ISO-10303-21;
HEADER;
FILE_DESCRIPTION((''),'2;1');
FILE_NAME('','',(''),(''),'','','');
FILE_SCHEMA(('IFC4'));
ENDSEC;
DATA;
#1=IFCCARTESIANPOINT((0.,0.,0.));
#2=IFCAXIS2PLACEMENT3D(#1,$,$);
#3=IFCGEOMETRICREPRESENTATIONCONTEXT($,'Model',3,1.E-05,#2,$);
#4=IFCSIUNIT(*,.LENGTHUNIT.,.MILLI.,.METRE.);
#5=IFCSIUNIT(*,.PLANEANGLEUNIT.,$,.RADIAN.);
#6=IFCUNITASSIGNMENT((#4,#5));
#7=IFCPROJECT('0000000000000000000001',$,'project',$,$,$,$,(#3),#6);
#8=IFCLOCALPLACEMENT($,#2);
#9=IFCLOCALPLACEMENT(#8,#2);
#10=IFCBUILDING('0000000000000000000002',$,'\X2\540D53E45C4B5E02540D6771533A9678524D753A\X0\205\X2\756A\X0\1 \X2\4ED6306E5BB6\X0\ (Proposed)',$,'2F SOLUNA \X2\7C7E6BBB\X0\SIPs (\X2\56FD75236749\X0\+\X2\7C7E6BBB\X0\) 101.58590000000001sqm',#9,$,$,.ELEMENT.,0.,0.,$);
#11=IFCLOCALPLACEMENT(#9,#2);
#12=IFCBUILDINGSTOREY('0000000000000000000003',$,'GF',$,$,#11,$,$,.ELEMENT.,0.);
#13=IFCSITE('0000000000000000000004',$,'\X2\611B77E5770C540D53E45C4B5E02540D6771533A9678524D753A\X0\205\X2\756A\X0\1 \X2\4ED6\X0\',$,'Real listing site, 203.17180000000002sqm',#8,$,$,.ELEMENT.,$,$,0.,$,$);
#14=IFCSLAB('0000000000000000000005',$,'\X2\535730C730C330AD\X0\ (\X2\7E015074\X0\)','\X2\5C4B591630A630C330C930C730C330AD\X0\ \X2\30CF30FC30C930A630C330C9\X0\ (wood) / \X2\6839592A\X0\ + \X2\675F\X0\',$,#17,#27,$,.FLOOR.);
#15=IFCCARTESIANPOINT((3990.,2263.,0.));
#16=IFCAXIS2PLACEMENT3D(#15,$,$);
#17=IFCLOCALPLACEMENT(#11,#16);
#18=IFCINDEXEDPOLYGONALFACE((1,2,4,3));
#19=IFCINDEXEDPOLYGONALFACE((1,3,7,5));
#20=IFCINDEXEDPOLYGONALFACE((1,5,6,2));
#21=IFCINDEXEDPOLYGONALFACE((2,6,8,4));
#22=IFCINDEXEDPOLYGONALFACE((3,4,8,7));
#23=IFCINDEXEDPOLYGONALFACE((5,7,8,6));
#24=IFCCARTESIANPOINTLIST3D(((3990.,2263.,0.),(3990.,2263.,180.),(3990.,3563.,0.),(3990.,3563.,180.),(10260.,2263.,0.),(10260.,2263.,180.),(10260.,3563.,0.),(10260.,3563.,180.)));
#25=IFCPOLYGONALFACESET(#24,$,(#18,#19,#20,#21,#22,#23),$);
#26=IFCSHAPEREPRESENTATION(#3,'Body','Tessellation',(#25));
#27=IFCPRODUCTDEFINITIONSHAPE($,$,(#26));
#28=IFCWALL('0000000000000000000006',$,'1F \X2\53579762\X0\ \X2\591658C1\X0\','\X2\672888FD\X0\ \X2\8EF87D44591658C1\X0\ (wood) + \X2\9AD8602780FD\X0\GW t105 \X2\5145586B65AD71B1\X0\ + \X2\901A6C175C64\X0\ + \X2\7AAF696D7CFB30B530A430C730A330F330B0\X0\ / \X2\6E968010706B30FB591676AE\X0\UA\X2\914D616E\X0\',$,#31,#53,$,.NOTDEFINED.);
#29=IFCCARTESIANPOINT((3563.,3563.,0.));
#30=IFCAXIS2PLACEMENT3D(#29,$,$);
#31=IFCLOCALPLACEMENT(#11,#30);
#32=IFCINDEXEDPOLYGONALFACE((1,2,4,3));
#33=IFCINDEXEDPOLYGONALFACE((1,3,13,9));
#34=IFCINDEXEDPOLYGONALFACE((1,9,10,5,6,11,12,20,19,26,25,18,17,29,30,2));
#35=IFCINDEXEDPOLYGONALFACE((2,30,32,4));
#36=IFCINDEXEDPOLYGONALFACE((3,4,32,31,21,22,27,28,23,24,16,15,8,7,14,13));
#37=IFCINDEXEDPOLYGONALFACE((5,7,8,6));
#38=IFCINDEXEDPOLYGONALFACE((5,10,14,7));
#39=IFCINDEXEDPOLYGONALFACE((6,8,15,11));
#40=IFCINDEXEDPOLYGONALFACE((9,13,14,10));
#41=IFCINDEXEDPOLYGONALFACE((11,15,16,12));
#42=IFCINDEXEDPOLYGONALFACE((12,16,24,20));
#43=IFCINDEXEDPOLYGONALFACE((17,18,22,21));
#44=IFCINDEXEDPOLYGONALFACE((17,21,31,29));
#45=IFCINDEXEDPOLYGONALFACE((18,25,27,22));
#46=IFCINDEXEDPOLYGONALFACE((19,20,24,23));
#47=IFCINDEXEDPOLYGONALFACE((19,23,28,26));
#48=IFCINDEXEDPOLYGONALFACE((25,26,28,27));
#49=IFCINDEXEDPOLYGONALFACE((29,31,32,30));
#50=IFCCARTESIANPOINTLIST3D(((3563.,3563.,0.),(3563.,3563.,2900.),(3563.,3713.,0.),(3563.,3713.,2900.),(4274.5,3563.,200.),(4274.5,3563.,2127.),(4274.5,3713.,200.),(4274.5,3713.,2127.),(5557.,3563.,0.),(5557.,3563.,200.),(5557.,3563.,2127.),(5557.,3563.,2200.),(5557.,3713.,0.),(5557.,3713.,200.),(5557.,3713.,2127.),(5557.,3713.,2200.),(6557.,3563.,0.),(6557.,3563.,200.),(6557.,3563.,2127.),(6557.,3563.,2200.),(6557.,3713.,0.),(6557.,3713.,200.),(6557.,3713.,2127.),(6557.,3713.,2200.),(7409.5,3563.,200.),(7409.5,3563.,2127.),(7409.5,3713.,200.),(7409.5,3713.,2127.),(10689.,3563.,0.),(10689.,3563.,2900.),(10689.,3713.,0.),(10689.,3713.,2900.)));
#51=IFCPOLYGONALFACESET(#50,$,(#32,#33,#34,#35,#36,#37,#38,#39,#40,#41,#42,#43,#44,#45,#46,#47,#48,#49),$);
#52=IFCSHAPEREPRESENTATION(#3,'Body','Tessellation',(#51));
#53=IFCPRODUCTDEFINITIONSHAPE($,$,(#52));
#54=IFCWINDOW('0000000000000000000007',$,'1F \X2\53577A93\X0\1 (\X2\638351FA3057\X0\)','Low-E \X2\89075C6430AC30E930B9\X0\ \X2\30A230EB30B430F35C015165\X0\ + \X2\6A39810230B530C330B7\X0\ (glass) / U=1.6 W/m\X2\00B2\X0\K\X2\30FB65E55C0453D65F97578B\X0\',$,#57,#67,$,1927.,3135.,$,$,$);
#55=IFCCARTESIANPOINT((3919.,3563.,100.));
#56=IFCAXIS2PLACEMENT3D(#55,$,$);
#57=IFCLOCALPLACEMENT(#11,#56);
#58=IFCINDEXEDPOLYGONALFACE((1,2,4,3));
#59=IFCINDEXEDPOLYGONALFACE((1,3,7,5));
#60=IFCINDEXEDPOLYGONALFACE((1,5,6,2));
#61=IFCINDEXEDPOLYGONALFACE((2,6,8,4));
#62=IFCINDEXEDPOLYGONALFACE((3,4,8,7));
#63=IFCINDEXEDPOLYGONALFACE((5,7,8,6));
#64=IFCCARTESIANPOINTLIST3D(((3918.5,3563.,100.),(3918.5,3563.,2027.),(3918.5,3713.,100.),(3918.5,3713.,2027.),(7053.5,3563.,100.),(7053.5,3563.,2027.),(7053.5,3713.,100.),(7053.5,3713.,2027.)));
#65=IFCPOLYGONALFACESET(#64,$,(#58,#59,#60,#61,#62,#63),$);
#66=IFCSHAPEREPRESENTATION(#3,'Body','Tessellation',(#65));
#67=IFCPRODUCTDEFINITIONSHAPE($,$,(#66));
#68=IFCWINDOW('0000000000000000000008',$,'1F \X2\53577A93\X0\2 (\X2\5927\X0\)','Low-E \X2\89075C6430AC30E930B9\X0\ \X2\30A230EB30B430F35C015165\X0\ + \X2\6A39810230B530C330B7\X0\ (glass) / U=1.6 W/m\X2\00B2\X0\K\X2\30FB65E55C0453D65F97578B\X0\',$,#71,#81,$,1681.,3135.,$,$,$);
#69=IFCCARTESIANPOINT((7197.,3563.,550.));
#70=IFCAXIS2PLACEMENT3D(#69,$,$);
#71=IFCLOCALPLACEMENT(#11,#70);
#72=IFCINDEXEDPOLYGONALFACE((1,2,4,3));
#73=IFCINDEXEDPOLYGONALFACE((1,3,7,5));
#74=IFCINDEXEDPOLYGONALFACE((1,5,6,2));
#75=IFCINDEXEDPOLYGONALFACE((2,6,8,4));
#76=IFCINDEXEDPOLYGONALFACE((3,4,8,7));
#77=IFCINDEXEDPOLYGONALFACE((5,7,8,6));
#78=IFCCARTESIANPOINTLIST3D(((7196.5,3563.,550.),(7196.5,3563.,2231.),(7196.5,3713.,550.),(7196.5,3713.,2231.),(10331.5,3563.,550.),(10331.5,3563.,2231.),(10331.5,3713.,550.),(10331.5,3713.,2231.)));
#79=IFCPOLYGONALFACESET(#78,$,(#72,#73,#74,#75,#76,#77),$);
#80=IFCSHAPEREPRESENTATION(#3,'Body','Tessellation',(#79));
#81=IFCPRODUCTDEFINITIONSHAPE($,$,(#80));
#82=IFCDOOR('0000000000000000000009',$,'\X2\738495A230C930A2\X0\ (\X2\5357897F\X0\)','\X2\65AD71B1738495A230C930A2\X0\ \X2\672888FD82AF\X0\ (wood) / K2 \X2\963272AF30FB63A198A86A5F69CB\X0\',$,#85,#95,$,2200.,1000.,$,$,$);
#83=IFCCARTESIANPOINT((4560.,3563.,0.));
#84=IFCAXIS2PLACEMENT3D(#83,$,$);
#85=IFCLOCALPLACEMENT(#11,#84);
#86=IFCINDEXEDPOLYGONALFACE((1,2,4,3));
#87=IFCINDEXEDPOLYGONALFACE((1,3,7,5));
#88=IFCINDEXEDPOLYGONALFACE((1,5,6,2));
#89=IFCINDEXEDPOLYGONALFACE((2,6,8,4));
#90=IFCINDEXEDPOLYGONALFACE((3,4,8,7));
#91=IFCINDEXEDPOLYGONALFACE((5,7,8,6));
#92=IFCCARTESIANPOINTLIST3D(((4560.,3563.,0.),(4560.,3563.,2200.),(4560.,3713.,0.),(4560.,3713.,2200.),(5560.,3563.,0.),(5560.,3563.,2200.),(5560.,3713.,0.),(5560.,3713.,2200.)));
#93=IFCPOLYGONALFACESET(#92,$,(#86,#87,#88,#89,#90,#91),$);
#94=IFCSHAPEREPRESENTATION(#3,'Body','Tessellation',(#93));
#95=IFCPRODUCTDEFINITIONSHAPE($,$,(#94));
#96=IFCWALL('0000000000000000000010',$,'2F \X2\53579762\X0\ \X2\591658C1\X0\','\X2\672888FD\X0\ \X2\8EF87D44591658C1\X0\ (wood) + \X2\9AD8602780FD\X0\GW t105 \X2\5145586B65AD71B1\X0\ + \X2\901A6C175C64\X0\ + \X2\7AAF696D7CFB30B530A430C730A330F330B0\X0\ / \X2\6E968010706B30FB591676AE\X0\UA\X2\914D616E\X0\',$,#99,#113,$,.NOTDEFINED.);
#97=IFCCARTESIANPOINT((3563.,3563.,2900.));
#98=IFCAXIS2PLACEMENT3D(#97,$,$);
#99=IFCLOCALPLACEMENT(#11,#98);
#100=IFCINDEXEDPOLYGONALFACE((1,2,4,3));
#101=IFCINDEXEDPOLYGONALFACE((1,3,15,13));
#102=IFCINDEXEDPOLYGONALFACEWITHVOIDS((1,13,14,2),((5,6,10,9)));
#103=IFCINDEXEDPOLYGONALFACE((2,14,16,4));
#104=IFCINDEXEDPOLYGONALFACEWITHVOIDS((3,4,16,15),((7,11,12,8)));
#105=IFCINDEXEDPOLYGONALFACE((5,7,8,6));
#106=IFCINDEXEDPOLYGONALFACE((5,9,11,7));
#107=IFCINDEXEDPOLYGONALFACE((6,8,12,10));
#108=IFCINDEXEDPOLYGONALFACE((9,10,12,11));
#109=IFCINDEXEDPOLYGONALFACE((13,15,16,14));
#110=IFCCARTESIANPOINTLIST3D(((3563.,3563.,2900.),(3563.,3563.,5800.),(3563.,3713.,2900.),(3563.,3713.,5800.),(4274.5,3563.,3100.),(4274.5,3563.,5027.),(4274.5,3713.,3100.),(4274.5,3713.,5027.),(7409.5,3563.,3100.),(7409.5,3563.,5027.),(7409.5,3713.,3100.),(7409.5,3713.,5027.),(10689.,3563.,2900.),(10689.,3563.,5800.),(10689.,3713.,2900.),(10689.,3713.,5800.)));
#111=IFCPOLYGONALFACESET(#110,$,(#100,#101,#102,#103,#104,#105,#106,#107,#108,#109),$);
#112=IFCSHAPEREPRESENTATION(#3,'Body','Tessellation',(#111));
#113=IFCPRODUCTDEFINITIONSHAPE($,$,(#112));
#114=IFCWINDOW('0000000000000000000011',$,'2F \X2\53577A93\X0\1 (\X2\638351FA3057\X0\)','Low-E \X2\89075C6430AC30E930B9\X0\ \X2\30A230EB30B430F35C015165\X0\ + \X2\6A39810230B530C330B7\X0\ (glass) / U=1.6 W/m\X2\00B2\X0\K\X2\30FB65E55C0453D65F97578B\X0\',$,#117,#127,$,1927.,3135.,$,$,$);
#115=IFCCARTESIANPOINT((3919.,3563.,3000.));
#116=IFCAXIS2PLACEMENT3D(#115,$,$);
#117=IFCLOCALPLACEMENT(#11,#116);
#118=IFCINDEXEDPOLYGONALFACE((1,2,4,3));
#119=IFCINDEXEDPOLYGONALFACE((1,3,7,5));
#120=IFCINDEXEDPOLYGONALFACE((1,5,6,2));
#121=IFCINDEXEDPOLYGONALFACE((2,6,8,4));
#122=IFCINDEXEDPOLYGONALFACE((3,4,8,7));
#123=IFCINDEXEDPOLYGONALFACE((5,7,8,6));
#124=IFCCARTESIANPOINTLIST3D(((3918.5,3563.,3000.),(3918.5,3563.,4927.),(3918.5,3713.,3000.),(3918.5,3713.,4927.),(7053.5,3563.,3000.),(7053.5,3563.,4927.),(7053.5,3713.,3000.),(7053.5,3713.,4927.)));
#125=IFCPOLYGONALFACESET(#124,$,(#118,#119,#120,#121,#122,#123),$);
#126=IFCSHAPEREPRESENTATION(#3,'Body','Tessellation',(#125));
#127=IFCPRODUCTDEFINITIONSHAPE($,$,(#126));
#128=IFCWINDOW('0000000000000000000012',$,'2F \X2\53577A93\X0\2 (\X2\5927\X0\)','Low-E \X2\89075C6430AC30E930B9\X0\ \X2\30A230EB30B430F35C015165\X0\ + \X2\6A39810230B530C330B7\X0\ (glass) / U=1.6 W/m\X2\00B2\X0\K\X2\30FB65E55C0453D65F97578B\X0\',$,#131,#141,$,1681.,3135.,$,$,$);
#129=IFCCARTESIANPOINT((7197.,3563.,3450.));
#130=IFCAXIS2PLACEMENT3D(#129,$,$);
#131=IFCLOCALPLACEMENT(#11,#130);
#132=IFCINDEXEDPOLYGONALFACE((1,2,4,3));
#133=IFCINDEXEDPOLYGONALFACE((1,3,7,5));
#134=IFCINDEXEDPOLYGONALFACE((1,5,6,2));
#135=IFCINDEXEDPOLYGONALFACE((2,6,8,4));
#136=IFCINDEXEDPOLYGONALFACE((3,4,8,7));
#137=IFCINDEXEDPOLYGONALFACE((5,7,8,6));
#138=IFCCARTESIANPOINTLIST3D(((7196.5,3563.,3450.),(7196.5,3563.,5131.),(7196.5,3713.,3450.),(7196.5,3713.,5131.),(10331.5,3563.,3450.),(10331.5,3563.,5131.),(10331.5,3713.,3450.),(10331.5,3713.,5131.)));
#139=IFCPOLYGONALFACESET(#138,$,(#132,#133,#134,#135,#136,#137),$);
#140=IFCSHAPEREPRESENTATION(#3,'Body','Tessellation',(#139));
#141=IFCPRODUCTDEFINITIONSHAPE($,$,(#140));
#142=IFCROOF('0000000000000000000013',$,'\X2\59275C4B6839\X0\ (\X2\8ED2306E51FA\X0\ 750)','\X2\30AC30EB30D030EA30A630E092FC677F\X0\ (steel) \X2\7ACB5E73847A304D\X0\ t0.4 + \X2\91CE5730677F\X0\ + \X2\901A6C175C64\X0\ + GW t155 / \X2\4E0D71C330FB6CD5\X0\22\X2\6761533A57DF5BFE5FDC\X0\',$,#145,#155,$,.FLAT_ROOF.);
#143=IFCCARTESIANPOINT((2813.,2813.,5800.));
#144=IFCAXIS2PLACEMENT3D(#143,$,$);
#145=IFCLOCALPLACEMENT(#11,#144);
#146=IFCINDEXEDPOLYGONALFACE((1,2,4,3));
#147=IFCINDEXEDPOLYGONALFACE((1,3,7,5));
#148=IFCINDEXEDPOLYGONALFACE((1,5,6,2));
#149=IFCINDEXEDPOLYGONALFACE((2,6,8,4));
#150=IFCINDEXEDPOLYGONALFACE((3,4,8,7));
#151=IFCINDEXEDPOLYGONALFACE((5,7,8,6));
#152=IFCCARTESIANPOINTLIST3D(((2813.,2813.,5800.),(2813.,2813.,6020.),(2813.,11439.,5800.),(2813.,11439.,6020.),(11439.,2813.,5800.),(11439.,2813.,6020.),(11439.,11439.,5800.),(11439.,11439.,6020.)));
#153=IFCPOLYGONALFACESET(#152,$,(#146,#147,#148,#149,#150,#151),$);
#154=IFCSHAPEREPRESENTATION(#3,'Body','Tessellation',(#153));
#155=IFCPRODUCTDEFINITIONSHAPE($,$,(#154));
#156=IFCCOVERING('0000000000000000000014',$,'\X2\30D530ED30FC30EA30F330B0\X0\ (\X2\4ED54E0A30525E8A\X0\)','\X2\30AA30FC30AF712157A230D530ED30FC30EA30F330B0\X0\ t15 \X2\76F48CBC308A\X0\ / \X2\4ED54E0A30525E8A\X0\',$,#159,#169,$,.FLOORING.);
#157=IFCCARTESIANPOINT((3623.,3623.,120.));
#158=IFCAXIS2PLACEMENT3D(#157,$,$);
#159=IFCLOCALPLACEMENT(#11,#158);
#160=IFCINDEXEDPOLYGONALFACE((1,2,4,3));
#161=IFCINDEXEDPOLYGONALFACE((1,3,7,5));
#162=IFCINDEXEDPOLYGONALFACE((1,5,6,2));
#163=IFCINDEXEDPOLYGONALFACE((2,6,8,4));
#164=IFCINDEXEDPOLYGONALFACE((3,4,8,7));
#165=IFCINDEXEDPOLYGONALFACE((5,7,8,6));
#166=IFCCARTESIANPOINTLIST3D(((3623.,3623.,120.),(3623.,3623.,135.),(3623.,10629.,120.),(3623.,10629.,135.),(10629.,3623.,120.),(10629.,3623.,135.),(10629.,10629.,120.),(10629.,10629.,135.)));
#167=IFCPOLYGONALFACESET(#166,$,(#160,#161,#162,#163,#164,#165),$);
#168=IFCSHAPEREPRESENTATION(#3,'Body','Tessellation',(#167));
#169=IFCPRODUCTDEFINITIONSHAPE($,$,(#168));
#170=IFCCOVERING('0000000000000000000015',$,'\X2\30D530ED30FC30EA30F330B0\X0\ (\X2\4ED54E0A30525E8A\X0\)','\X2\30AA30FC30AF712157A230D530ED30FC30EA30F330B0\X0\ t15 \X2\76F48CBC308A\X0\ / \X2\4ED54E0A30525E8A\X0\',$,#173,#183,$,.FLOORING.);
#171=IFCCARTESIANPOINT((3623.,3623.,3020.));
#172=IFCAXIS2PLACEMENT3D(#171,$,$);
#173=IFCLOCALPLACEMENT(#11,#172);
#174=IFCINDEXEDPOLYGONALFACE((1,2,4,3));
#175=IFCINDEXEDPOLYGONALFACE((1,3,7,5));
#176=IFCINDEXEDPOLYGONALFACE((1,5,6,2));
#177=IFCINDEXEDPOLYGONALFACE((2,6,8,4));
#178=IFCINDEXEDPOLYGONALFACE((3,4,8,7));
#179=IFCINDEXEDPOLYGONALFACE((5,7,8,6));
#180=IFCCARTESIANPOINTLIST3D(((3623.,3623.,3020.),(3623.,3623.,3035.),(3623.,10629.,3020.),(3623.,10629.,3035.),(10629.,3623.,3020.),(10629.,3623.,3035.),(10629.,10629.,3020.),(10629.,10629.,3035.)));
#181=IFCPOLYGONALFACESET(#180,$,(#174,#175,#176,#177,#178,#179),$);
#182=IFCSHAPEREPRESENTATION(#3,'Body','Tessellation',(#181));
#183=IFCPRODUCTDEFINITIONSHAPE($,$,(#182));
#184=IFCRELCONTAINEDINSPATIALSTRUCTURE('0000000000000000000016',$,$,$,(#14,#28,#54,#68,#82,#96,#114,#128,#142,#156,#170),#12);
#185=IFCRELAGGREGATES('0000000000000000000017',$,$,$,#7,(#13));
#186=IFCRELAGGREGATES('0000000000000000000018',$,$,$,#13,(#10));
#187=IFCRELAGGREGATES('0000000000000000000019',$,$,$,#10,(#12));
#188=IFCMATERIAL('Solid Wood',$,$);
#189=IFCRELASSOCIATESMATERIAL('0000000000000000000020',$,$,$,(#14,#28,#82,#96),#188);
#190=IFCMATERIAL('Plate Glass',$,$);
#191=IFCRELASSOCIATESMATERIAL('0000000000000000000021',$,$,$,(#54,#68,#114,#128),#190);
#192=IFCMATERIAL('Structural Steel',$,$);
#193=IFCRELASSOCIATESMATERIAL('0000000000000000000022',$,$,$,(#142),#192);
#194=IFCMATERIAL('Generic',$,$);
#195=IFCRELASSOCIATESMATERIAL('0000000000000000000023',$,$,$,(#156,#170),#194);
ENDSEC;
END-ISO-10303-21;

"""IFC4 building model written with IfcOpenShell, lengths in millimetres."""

from ifc_helpers import new_model, si_unit, frame, frame_2d, origin, place, context, project, spatial, rectangle, extrude, material, element, fill, save


model = new_model("IFC4")

# Units and contexts
model_context = context("Model", 3, precision=1e-05, world=origin())
ifc_project = project(units=[si_unit("LENGTHUNIT", "METRE", prefix="MILLI"), si_unit("PLANEANGLEUNIT", "RADIAN")], contexts=[model_context])

# Site, building, storey
site_placement = place(None, origin())
site = spatial("IfcSite", under=ifc_project, at=site_placement, Name="愛知県名古屋市名東区陸前町205番1 他", ObjectType="Real listing site, 203.17180000000002sqm", CompositionType="ELEMENT", RefElevation=0.0)
building_placement = place(site_placement, origin())
building = spatial("IfcBuilding", under=site, at=building_placement, Name="名古屋市名東区陸前町205番1 他の家 (Proposed)", ObjectType="2F SOLUNA 籾殻SIPs (国産杉+籾殻) 101.58590000000001sqm", CompositionType="ELEMENT", ElevationOfRefHeight=0.0, ElevationOfTerrain=0.0)
storey_placement = place(building_placement, origin())
storey = spatial("IfcBuildingStorey", under=building, at=storey_placement, Name="GF", CompositionType="ELEMENT", Elevation=0.0)

# Slab
ifc_material_1 = material(Name="Solid Wood")
slab_1_placement = place(storey_placement, frame((3990.0, 2263.0, 0.0)))
element("IfcSlab", 1, at=slab_1_placement, inside=storey, material=ifc_material_1, Name="南デッキ (縁側)", Description="屋外ウッドデッキ ハードウッド (wood) / 根太 + 束", PredefinedType="FLOOR", context=model_context, shape_type="SweptSolid", body=[
    extrude(rectangle(XDim=6270.0, YDim=1300.0, at=frame_2d((3135.0, 650.0))), frame((3990.0, 2263.0, 0.0)), (0.0, 0.0, 1.0), 180.0),
])

# Wall, openings, windows, door
wall_1_placement = place(storey_placement, frame((3563.0, 3563.0, 0.0)))
wall_1 = element("IfcWall", 2, at=wall_1_placement, inside=storey, material=ifc_material_1, Name="1F 南面 外壁", Description="木製 軸組外壁 (wood) + 高性能GW t105 充填断熱 + 通気層 + 窯業系サイディング / 準耐火・外皮UA配慮", PredefinedType="NOTDEFINED", context=model_context, shape_type="SweptSolid", body=[
    extrude(rectangle(XDim=7126.0, YDim=150.0, at=frame_2d((3563.0, 75.0))), frame((3563.0, 3563.0, 0.0)), (0.0, 0.0, 1.0), 2900.0),
])
opening_1_placement = place(storey_placement, frame((3919.0, 3563.0, 100.0)))
opening_1 = element("IfcOpeningElement", 3, at=opening_1_placement, cuts=wall_1, PredefinedType="NOTDEFINED", context=model_context, shape_type="SweptSolid", body=[
    extrude(rectangle(XDim=3135.0, YDim=150.0, at=frame_2d((1567.0, 75.0))), frame((3919.0, 3563.0, 100.0)), (0.0, 0.0, 1.0), 1927.0),
])
opening_2_placement = place(storey_placement, frame((7197.0, 3563.0, 550.0)))
opening_2 = element("IfcOpeningElement", 4, at=opening_2_placement, cuts=wall_1, PredefinedType="NOTDEFINED", context=model_context, shape_type="SweptSolid", body=[
    extrude(rectangle(XDim=3135.0, YDim=150.0, at=frame_2d((1567.0, 75.0))), frame((7197.0, 3563.0, 550.0)), (0.0, 0.0, 1.0), 1681.0),
])
opening_3_placement = place(storey_placement, frame((4560.0, 3563.0, 0.0)))
opening_3 = element("IfcOpeningElement", 5, at=opening_3_placement, cuts=wall_1, PredefinedType="NOTDEFINED", context=model_context, shape_type="SweptSolid", body=[
    extrude(rectangle(XDim=1000.0, YDim=150.0, at=frame_2d((500.0, 75.0))), frame((4560.0, 3563.0, 0.0)), (0.0, 0.0, 1.0), 2200.0),
])
ifc_material_2 = material(Name="Plate Glass")
window_1_placement = place(storey_placement, frame((3919.0, 3563.0, 100.0)))
window_1 = element("IfcWindow", 6, at=window_1_placement, inside=storey, material=ifc_material_2, Name="1F 南窓1 (掃出し)", Description="Low-E 複層ガラス アルゴン封入 + 樹脂サッシ (glass) / U=1.6 W/m²K・日射取得型", OverallHeight=1927.0, OverallWidth=3135.0, context=model_context, shape_type="SweptSolid", body=[
    extrude(rectangle(XDim=3135.0, YDim=150.0, at=frame_2d((1567.0, 75.0))), frame((3919.0, 3563.0, 100.0)), (0.0, 0.0, 1.0), 1927.0),
])
fill(opening_1, window_1)
window_2_placement = place(storey_placement, frame((7197.0, 3563.0, 550.0)))
window_2 = element("IfcWindow", 7, at=window_2_placement, inside=storey, material=ifc_material_2, Name="1F 南窓2 (大)", Description="Low-E 複層ガラス アルゴン封入 + 樹脂サッシ (glass) / U=1.6 W/m²K・日射取得型", OverallHeight=1681.0, OverallWidth=3135.0, context=model_context, shape_type="SweptSolid", body=[
    extrude(rectangle(XDim=3135.0, YDim=150.0, at=frame_2d((1567.0, 75.0))), frame((7197.0, 3563.0, 550.0)), (0.0, 0.0, 1.0), 1681.0),
])
fill(opening_2, window_2)
door_placement = place(storey_placement, frame((4560.0, 3563.0, 0.0)))
door = element("IfcDoor", 8, at=door_placement, inside=storey, material=ifc_material_1, Name="玄関ドア (南西)", Description="断熱玄関ドア 木製芯 (wood) / K2 防犯・採風機構", OverallHeight=2200.0, OverallWidth=1000.0, context=model_context, shape_type="SweptSolid", body=[
    extrude(rectangle(XDim=1000.0, YDim=150.0, at=frame_2d((500.0, 75.0))), frame((4560.0, 3563.0, 0.0)), (0.0, 0.0, 1.0), 2200.0),
])
fill(opening_3, door)

# Wall, openings, windows
wall_2_placement = place(storey_placement, frame((3563.0, 3563.0, 2900.0)))
wall_2 = element("IfcWall", 9, at=wall_2_placement, inside=storey, material=ifc_material_1, Name="2F 南面 外壁", Description="木製 軸組外壁 (wood) + 高性能GW t105 充填断熱 + 通気層 + 窯業系サイディング / 準耐火・外皮UA配慮", PredefinedType="NOTDEFINED", context=model_context, shape_type="SweptSolid", body=[
    extrude(rectangle(XDim=7126.0, YDim=150.0, at=frame_2d((3563.0, 75.0))), frame((3563.0, 3563.0, 2900.0)), (0.0, 0.0, 1.0), 2900.0),
])
opening_4_placement = place(storey_placement, frame((3919.0, 3563.0, 3000.0)))
opening_4 = element("IfcOpeningElement", 10, at=opening_4_placement, cuts=wall_2, PredefinedType="NOTDEFINED", context=model_context, shape_type="SweptSolid", body=[
    extrude(rectangle(XDim=3135.0, YDim=150.0, at=frame_2d((1567.0, 75.0))), frame((3919.0, 3563.0, 3000.0)), (0.0, 0.0, 1.0), 1927.0),
])
opening_5_placement = place(storey_placement, frame((7197.0, 3563.0, 3450.0)))
opening_5 = element("IfcOpeningElement", 11, at=opening_5_placement, cuts=wall_2, PredefinedType="NOTDEFINED", context=model_context, shape_type="SweptSolid", body=[
    extrude(rectangle(XDim=3135.0, YDim=150.0, at=frame_2d((1567.0, 75.0))), frame((7197.0, 3563.0, 3450.0)), (0.0, 0.0, 1.0), 1681.0),
])
window_3_placement = place(storey_placement, frame((3919.0, 3563.0, 3000.0)))
window_3 = element("IfcWindow", 12, at=window_3_placement, inside=storey, material=ifc_material_2, Name="2F 南窓1 (掃出し)", Description="Low-E 複層ガラス アルゴン封入 + 樹脂サッシ (glass) / U=1.6 W/m²K・日射取得型", OverallHeight=1927.0, OverallWidth=3135.0, context=model_context, shape_type="SweptSolid", body=[
    extrude(rectangle(XDim=3135.0, YDim=150.0, at=frame_2d((1567.0, 75.0))), frame((3919.0, 3563.0, 3000.0)), (0.0, 0.0, 1.0), 1927.0),
])
fill(opening_4, window_3)
window_4_placement = place(storey_placement, frame((7197.0, 3563.0, 3450.0)))
window_4 = element("IfcWindow", 13, at=window_4_placement, inside=storey, material=ifc_material_2, Name="2F 南窓2 (大)", Description="Low-E 複層ガラス アルゴン封入 + 樹脂サッシ (glass) / U=1.6 W/m²K・日射取得型", OverallHeight=1681.0, OverallWidth=3135.0, context=model_context, shape_type="SweptSolid", body=[
    extrude(rectangle(XDim=3135.0, YDim=150.0, at=frame_2d((1567.0, 75.0))), frame((7197.0, 3563.0, 3450.0)), (0.0, 0.0, 1.0), 1681.0),
])
fill(opening_5, window_4)

# Roof
ifc_material_3 = material(Name="Structural Steel")
roof_placement = place(storey_placement, frame((2813.0, 2813.0, 5800.0)))
element("IfcRoof", 14, at=roof_placement, inside=storey, material=ifc_material_3, Name="大屋根 (軒の出 750)", Description="ガルバリウム鋼板 (steel) 立平葺き t0.4 + 野地板 + 通気層 + GW t155 / 不燃・法22条区域対応", PredefinedType="FLAT_ROOF", context=model_context, shape_type="SweptSolid", body=[
    extrude(rectangle(XDim=8626.0, YDim=8626.0, at=frame_2d((4313.0, 4313.0))), frame((2813.0, 2813.0, 5800.0)), (0.0, 0.0, 1.0), 220.0),
])

# Coverings
ifc_material_4 = material(Name="Generic")
covering_1_placement = place(storey_placement, frame((3623.0, 3623.0, 120.0)))
element("IfcCovering", 15, at=covering_1_placement, inside=storey, material=ifc_material_4, Name="フローリング (仕上げ床)", Description="オーク無垢フローリング t15 直貼り / 仕上げ床", PredefinedType="FLOORING", context=model_context, shape_type="SweptSolid", body=[
    extrude(rectangle(XDim=7006.0, YDim=7006.0, at=frame_2d((3503.0, 3503.0))), frame((3623.0, 3623.0, 120.0)), (0.0, 0.0, 1.0), 15.0),
])
covering_2_placement = place(storey_placement, frame((3623.0, 3623.0, 3020.0)))
element("IfcCovering", 16, at=covering_2_placement, inside=storey, material=ifc_material_4, Name="フローリング (仕上げ床)", Description="オーク無垢フローリング t15 直貼り / 仕上げ床", PredefinedType="FLOORING", context=model_context, shape_type="SweptSolid", body=[
    extrude(rectangle(XDim=7006.0, YDim=7006.0, at=frame_2d((3503.0, 3503.0))), frame((3623.0, 3623.0, 3020.0)), (0.0, 0.0, 1.0), 15.0),
])

save(model, "model.ifc")
